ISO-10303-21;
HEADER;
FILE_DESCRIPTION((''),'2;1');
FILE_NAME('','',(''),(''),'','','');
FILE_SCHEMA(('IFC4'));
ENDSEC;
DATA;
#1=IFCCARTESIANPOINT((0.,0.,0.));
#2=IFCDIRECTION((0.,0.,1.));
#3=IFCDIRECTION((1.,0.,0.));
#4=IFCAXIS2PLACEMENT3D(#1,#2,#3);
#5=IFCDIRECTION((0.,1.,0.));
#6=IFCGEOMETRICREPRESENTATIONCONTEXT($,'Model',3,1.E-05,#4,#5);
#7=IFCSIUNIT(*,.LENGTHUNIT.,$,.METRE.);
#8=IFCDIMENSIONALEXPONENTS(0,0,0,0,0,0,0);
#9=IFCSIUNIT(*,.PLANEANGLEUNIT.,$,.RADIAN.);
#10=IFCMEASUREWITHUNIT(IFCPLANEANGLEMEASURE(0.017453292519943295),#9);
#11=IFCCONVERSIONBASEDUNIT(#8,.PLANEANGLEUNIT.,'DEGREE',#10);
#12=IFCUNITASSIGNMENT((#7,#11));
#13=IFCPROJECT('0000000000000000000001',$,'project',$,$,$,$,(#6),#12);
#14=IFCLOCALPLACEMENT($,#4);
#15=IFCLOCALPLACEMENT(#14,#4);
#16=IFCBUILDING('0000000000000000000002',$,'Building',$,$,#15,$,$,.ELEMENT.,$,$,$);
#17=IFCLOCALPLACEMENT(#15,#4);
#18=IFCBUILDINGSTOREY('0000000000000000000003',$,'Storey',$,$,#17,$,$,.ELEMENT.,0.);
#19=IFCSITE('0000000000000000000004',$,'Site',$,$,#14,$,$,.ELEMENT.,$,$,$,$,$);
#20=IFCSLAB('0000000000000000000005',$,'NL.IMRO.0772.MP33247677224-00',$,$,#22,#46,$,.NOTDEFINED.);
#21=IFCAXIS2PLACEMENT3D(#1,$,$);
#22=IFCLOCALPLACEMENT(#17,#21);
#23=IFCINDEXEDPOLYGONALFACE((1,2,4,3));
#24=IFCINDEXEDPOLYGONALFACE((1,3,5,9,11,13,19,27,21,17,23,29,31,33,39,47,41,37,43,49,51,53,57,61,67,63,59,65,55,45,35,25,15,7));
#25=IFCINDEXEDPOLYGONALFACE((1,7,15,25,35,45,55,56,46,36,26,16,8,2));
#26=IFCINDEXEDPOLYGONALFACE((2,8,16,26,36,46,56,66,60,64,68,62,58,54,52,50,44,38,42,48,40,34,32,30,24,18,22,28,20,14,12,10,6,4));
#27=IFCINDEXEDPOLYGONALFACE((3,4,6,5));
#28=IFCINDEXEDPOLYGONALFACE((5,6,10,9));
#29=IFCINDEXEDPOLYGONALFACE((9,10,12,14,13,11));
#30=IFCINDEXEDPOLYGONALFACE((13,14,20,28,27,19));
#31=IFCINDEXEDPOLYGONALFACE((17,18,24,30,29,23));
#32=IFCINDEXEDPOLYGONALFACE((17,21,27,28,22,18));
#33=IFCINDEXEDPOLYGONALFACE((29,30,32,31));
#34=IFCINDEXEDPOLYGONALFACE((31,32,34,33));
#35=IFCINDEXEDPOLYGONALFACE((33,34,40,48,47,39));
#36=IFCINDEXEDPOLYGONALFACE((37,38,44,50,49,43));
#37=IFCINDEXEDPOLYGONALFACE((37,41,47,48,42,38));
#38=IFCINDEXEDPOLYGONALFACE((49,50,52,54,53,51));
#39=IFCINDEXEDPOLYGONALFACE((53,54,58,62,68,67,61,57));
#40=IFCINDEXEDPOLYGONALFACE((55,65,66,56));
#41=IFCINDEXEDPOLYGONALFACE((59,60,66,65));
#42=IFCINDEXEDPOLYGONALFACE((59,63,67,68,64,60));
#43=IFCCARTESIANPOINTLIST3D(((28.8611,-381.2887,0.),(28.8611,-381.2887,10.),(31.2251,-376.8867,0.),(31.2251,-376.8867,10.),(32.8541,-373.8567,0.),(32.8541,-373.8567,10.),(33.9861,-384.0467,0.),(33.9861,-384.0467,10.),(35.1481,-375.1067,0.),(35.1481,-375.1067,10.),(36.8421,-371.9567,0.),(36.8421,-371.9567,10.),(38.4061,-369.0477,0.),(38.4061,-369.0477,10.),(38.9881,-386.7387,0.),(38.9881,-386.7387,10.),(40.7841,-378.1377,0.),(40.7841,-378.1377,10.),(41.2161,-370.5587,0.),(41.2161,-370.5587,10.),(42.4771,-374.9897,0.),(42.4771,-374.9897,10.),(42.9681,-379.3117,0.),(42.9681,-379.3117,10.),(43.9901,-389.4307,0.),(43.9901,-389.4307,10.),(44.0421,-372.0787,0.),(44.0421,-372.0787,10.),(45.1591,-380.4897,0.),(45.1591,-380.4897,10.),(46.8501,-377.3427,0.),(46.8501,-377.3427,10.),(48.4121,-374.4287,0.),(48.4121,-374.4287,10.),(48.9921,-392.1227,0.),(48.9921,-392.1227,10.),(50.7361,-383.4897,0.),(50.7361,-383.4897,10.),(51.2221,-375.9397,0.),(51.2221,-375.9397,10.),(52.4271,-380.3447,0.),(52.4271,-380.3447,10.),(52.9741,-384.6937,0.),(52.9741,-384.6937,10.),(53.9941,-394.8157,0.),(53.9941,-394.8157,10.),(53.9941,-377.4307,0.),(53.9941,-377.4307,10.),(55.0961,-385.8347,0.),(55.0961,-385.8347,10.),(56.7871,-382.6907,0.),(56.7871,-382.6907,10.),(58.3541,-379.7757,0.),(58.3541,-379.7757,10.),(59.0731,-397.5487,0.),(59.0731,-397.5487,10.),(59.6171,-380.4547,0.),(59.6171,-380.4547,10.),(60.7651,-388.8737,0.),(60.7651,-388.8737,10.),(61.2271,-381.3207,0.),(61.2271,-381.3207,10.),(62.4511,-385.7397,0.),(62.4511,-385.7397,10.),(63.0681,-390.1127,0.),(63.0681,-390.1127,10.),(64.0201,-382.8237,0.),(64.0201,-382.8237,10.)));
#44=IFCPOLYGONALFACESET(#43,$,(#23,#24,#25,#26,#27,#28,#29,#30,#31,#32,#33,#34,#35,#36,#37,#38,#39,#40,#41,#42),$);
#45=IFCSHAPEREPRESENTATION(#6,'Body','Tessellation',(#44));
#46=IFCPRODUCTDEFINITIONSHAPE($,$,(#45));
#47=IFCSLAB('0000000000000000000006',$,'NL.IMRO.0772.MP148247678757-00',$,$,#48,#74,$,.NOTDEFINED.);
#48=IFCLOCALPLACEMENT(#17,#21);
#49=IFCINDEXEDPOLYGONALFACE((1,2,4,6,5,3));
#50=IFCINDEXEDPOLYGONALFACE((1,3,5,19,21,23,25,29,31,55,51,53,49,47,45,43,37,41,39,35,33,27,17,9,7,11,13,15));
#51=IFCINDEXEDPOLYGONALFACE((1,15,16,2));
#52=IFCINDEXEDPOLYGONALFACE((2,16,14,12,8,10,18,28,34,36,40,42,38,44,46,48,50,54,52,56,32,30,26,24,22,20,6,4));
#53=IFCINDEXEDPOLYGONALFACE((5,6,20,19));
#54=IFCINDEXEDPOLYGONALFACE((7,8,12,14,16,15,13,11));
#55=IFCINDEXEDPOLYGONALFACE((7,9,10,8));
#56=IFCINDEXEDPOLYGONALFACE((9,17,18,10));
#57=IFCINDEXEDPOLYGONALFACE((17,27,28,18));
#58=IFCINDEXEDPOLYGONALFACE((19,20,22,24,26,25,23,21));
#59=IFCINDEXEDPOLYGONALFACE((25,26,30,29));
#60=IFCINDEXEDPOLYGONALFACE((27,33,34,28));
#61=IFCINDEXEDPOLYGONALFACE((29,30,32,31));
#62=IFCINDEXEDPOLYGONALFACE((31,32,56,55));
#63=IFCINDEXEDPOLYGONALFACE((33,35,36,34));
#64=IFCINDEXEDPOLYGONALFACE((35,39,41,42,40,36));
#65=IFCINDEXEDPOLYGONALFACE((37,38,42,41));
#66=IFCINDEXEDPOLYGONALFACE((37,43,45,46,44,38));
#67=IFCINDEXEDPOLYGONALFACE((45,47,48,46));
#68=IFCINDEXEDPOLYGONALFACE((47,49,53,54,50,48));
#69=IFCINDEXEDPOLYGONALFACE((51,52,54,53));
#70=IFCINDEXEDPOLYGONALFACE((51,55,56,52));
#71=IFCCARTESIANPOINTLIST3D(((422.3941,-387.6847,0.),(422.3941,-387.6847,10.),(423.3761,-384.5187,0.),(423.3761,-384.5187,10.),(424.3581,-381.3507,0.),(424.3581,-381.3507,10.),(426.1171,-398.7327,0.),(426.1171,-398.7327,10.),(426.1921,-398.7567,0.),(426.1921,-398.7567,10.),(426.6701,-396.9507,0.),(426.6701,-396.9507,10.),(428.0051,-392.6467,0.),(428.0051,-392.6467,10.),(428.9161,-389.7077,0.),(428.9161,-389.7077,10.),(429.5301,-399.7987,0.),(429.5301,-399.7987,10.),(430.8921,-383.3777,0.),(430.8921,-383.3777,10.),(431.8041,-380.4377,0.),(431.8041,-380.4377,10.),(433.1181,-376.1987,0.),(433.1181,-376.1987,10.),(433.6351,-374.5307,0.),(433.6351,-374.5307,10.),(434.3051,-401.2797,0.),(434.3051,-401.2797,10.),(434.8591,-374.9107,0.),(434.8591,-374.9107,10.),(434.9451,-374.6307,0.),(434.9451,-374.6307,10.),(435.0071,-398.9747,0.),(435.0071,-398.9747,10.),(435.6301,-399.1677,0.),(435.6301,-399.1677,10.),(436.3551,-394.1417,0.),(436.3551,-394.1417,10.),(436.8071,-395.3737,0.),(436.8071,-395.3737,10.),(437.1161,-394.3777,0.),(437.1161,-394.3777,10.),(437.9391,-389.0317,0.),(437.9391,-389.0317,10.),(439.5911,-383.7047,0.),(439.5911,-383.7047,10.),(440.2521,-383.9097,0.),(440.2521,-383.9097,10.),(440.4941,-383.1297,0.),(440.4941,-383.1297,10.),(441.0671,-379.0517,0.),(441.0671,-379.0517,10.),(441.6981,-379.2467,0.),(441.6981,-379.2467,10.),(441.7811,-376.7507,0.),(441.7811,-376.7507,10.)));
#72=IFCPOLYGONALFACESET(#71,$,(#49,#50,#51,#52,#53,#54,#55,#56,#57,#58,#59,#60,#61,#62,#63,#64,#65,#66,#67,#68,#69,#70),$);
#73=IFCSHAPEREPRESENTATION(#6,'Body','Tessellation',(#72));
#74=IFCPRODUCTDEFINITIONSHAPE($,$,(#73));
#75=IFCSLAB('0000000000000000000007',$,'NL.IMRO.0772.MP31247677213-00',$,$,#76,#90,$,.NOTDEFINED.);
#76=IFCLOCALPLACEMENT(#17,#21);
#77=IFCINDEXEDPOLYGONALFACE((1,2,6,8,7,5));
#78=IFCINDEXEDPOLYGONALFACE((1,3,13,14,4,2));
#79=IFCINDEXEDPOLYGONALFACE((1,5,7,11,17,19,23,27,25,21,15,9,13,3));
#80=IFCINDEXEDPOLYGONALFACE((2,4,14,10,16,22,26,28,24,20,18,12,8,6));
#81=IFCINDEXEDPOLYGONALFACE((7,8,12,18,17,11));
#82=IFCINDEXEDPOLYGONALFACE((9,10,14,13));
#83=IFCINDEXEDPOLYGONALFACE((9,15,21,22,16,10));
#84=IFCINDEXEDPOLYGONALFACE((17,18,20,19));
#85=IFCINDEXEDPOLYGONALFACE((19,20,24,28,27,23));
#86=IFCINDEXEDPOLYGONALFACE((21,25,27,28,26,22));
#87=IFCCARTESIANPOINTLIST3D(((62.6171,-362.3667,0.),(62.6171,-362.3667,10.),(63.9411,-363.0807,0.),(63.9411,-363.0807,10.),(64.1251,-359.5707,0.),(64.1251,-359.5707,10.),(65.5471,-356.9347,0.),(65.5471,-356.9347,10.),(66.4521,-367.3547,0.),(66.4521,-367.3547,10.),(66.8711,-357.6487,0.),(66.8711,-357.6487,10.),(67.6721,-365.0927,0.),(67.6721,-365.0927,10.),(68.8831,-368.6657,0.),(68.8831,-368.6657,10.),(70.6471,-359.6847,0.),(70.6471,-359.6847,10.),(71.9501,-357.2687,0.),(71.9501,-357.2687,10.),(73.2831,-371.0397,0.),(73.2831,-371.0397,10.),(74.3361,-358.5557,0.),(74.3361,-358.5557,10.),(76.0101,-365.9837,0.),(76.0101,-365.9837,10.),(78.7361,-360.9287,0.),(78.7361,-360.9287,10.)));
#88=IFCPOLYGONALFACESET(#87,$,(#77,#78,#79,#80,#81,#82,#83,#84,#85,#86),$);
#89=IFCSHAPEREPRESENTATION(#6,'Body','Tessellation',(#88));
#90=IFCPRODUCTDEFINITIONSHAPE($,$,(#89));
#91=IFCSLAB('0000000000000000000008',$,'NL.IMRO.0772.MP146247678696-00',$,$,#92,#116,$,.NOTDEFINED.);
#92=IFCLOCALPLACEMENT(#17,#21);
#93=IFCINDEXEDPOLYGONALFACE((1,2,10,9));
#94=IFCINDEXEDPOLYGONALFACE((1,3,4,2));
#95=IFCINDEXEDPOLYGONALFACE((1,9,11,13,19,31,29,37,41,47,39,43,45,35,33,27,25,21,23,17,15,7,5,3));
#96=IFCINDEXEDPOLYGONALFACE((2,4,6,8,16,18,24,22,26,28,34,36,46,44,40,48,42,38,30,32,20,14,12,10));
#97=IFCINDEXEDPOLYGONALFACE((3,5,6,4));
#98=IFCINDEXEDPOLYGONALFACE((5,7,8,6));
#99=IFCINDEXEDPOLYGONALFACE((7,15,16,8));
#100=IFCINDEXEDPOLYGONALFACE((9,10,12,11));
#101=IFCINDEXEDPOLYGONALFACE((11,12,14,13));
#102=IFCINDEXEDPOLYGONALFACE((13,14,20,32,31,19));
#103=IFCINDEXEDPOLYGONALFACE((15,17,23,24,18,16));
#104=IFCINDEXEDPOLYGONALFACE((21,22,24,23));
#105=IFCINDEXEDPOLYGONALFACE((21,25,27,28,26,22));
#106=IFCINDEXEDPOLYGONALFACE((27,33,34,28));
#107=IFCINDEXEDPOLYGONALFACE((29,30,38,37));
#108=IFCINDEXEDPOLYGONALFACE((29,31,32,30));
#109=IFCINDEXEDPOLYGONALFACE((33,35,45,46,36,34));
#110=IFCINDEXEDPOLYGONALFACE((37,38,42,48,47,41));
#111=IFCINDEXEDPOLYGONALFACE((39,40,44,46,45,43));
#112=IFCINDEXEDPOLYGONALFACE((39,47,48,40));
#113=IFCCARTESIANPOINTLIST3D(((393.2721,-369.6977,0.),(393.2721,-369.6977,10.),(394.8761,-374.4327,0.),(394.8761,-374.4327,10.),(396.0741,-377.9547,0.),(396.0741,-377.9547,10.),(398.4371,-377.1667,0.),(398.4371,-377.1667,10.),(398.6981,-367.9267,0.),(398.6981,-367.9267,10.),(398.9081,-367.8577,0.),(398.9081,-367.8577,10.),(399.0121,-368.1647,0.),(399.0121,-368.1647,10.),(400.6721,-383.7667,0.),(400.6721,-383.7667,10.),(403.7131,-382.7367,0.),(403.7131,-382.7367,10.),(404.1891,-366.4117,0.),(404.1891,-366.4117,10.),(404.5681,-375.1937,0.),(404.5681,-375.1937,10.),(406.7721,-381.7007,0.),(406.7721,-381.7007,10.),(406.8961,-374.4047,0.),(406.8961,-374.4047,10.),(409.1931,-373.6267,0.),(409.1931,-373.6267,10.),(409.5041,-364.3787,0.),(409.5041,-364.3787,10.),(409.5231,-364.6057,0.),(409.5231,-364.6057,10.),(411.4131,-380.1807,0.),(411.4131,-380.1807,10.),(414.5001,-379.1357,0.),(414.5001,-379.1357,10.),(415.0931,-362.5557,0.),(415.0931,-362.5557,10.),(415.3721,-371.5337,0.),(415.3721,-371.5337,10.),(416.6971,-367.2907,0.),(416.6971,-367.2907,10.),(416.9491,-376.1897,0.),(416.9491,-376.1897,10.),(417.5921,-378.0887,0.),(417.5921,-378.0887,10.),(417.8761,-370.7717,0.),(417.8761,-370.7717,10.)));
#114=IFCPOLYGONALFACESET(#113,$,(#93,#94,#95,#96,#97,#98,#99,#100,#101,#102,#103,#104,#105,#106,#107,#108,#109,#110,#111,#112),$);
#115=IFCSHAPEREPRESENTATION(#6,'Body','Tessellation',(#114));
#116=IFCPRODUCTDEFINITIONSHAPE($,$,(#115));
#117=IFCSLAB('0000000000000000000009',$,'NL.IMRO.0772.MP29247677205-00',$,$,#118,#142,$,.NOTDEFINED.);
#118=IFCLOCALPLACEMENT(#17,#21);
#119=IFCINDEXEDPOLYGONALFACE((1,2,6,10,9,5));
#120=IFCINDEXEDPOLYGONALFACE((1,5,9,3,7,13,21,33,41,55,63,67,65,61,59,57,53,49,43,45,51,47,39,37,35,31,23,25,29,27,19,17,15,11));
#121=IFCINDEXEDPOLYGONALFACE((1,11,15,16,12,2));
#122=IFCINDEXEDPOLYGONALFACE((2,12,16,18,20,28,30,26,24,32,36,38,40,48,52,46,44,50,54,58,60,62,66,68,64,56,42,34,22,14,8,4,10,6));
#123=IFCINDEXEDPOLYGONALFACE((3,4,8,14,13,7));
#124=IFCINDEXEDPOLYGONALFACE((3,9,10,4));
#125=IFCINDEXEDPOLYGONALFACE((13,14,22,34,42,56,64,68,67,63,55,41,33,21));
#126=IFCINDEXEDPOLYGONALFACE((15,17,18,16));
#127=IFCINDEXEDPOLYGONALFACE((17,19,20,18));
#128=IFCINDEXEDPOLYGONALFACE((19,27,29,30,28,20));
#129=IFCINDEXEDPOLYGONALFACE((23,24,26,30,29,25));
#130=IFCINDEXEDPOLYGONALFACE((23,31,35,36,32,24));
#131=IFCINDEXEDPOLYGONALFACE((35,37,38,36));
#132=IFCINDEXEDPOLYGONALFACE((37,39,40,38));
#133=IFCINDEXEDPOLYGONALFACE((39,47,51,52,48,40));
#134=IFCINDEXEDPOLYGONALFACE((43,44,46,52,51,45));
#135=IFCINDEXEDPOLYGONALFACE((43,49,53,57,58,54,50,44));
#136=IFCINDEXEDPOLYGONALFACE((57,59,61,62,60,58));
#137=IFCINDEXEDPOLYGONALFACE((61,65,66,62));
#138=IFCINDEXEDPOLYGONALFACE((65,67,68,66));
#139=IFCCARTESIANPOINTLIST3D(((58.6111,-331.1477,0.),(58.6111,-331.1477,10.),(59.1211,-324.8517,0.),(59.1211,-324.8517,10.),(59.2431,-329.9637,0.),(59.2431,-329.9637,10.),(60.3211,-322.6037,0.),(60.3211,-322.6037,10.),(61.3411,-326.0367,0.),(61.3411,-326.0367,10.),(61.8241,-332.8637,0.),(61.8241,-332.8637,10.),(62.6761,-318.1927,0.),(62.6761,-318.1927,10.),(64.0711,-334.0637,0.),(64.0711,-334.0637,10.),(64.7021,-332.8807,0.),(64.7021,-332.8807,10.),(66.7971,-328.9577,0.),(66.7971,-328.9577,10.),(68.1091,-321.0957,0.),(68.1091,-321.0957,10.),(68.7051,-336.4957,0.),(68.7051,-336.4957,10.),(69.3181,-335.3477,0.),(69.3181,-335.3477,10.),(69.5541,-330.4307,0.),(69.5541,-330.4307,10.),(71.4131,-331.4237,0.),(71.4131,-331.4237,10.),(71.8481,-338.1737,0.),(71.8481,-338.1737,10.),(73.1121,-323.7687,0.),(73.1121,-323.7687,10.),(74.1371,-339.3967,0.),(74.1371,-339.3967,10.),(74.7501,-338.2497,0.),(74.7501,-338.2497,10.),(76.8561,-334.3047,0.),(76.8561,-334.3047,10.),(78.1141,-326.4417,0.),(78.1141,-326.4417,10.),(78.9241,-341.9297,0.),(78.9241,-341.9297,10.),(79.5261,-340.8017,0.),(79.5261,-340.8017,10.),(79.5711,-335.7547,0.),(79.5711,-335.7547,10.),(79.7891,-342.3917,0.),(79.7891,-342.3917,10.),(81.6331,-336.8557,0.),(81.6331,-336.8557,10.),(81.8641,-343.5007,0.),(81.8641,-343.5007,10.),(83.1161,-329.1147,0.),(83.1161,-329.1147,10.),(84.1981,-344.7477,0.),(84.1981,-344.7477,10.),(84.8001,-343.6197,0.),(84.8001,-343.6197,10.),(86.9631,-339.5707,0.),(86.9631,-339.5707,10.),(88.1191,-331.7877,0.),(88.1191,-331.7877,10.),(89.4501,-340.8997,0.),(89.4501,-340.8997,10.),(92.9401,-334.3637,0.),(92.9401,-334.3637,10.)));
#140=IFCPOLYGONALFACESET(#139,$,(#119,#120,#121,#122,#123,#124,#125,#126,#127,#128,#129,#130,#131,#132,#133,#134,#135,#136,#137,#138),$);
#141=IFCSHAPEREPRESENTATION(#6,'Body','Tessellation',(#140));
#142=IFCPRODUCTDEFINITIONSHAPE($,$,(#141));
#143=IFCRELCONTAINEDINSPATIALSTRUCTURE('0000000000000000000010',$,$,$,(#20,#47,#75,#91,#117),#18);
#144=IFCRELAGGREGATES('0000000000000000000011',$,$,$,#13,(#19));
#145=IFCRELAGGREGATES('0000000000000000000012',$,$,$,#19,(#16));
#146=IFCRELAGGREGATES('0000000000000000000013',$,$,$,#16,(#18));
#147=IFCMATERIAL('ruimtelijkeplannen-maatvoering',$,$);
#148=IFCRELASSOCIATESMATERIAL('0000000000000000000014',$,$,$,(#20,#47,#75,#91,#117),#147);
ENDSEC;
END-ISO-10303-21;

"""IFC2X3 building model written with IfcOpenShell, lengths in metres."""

from ifc_helpers import new_model, entity, si_unit, converted_unit, direction, origin_with_axes, place, context, project, spatial, polyline, outline, extrude, material, element, save


model = new_model("IFC2X3")

# Units and contexts
model_context = context("Model", 3, precision=1e-05, world=origin_with_axes(), true_north=direction((0.0, 1.0, 0.0)))
ifc_project = project(units=[si_unit("LENGTHUNIT", "METRE"), converted_unit("PLANEANGLEUNIT", "DEGREE", entity("IfcPlaneAngleMeasure", 0.017453292519943295), si_unit("PLANEANGLEUNIT", "RADIAN"), dimensions=[0, 0, 0, 0, 0, 0, 0])], contexts=[model_context])

# Site, building, storey
site_placement = place(None, origin_with_axes())
site = spatial("IfcSite", under=ifc_project, at=site_placement, Name="Site", CompositionType="ELEMENT")
building_placement = place(site_placement, origin_with_axes())
building = spatial("IfcBuilding", under=site, at=building_placement, Name="Building", CompositionType="ELEMENT")
storey_placement = place(building_placement, origin_with_axes())
storey = spatial("IfcBuildingStorey", under=building, at=storey_placement, Name="Storey", CompositionType="ELEMENT", Elevation=0.0)

# Slabs
ifc_material = material(Name="ruimtelijkeplannen-maatvoering")
slab_1_placement = place(storey_placement, origin_with_axes())
element("IfcSlab", 1, at=slab_1_placement, inside=storey, material=ifc_material, Name="NL.IMRO.0772.MP33247677224-00", PredefinedType="NOTDEFINED", context=model_context, shape_type="SweptSolid", body=[
    extrude(outline(polyline([(31.2251, -376.8867), (32.8541, -373.8567), (35.1481, -375.1067), (36.8421, -371.9567), (38.4061, -369.0477), (41.2161, -370.5587), (44.0421, -372.0787), (42.4771, -374.9897), (40.7841, -378.1377), (42.9681, -379.3117), (45.1591, -380.4897), (46.8501, -377.3427), (48.4121, -374.4287), (51.2221, -375.9397), (53.9941, -377.4307), (52.4271, -380.3447), (50.7361, -383.4897), (52.9741, -384.6937), (55.0961, -385.8347), (56.7871, -382.6907), (58.3541, -379.7757), (59.6171, -380.4547), (61.2271, -381.3207), (64.0201, -382.8237), (62.4511, -385.7397), (60.7651, -388.8737), (63.0681, -390.1127), (59.0731, -397.5487), (53.9941, -394.8157), (48.9921, -392.1227), (43.9901, -389.4307), (38.9881, -386.7387), (33.9861, -384.0467), (28.8611, -381.2887), (31.2251, -376.8867)])), origin_with_axes(), (0.0, 0.0, 1.0), 10.0),
])
slab_2_placement = place(storey_placement, origin_with_axes())
element("IfcSlab", 2, at=slab_2_placement, inside=storey, material=ifc_material, Name="NL.IMRO.0772.MP148247678757-00", PredefinedType="NOTDEFINED", context=model_context, shape_type="SweptSolid", body=[
    extrude(outline(polyline([(436.3551, -394.1417), (437.1161, -394.3777), (436.8071, -395.3737), (435.6301, -399.1677), (435.0071, -398.9747), (434.3051, -401.2797), (429.5301, -399.7987), (426.1921, -398.7567), (426.1171, -398.7327), (426.6701, -396.9507), (428.0051, -392.6467), (428.9161, -389.7077), (422.3941, -387.6847), (423.3761, -384.5187), (424.3581, -381.3507), (430.8921, -383.3777), (431.8041, -380.4377), (433.1181, -376.1987), (433.6351, -374.5307), (434.8591, -374.9107), (434.9451, -374.6307), (441.7811, -376.7507), (441.0671, -379.0517), (441.6981, -379.2467), (440.4941, -383.1297), (440.2521, -383.9097), (439.5911, -383.7047), (437.9391, -389.0317), (436.3551, -394.1417)])), origin_with_axes(), (0.0, 0.0, 1.0), 10.0),
])
slab_3_placement = place(storey_placement, origin_with_axes())
element("IfcSlab", 3, at=slab_3_placement, inside=storey, material=ifc_material, Name="NL.IMRO.0772.MP31247677213-00", PredefinedType="NOTDEFINED", context=model_context, shape_type="SweptSolid", body=[
    extrude(outline(polyline([(67.6721, -365.0927), (63.9411, -363.0807), (62.6171, -362.3667), (64.1251, -359.5707), (65.5471, -356.9347), (66.8711, -357.6487), (70.6471, -359.6847), (71.9501, -357.2687), (74.3361, -358.5557), (78.7361, -360.9287), (76.0101, -365.9837), (73.2831, -371.0397), (68.8831, -368.6657), (66.4521, -367.3547), (67.6721, -365.0927)])), origin_with_axes(), (0.0, 0.0, 1.0), 10.0),
])
slab_4_placement = place(storey_placement, origin_with_axes())
element("IfcSlab", 4, at=slab_4_placement, inside=storey, material=ifc_material, Name="NL.IMRO.0772.MP146247678696-00", PredefinedType="NOTDEFINED", context=model_context, shape_type="SweptSolid", body=[
    extrude(outline(polyline([(416.6971, -367.2907), (417.8761, -370.7717), (415.3721, -371.5337), (416.9491, -376.1897), (417.5921, -378.0887), (414.5001, -379.1357), (411.4131, -380.1807), (409.1931, -373.6267), (406.8961, -374.4047), (404.5681, -375.1937), (406.7721, -381.7007), (403.7131, -382.7367), (400.6721, -383.7667), (398.4371, -377.1667), (396.0741, -377.9547), (394.8761, -374.4327), (393.2721, -369.6977), (398.6981, -367.9267), (398.9081, -367.8577), (399.0121, -368.1647), (404.1891, -366.4117), (409.5231, -364.6057), (409.5041, -364.3787), (415.0931, -362.5557), (416.6971, -367.2907)])), origin_with_axes(), (0.0, 0.0, 1.0), 10.0),
])
slab_5_placement = place(storey_placement, origin_with_axes())
element("IfcSlab", 5, at=slab_5_placement, inside=storey, material=ifc_material, Name="NL.IMRO.0772.MP29247677205-00", PredefinedType="NOTDEFINED", context=model_context, shape_type="SweptSolid", body=[
    extrude(outline(polyline([(92.9401, -334.3637), (89.4501, -340.8997), (86.9631, -339.5707), (84.8001, -343.6197), (84.1981, -344.7477), (81.8641, -343.5007), (79.7891, -342.3917), (78.9241, -341.9297), (79.5261, -340.8017), (81.6331, -336.8557), (79.5711, -335.7547), (76.8561, -334.3047), (74.7501, -338.2497), (74.1371, -339.3967), (71.8481, -338.1737), (68.7051, -336.4957), (69.3181, -335.3477), (71.4131, -331.4237), (69.5541, -330.4307), (66.7971, -328.9577), (64.7021, -332.8807), (64.0711, -334.0637), (61.8241, -332.8637), (58.6111, -331.1477), (59.2431, -329.9637), (61.3411, -326.0367), (59.1211, -324.8517), (60.3211, -322.6037), (62.6761, -318.1927), (68.1091, -321.0957), (73.1121, -323.7687), (78.1141, -326.4417), (83.1161, -329.1147), (88.1191, -331.7877), (92.9401, -334.3637)])), origin_with_axes(), (0.0, 0.0, 1.0), 10.0),
])

save(model, "model.ifc")
